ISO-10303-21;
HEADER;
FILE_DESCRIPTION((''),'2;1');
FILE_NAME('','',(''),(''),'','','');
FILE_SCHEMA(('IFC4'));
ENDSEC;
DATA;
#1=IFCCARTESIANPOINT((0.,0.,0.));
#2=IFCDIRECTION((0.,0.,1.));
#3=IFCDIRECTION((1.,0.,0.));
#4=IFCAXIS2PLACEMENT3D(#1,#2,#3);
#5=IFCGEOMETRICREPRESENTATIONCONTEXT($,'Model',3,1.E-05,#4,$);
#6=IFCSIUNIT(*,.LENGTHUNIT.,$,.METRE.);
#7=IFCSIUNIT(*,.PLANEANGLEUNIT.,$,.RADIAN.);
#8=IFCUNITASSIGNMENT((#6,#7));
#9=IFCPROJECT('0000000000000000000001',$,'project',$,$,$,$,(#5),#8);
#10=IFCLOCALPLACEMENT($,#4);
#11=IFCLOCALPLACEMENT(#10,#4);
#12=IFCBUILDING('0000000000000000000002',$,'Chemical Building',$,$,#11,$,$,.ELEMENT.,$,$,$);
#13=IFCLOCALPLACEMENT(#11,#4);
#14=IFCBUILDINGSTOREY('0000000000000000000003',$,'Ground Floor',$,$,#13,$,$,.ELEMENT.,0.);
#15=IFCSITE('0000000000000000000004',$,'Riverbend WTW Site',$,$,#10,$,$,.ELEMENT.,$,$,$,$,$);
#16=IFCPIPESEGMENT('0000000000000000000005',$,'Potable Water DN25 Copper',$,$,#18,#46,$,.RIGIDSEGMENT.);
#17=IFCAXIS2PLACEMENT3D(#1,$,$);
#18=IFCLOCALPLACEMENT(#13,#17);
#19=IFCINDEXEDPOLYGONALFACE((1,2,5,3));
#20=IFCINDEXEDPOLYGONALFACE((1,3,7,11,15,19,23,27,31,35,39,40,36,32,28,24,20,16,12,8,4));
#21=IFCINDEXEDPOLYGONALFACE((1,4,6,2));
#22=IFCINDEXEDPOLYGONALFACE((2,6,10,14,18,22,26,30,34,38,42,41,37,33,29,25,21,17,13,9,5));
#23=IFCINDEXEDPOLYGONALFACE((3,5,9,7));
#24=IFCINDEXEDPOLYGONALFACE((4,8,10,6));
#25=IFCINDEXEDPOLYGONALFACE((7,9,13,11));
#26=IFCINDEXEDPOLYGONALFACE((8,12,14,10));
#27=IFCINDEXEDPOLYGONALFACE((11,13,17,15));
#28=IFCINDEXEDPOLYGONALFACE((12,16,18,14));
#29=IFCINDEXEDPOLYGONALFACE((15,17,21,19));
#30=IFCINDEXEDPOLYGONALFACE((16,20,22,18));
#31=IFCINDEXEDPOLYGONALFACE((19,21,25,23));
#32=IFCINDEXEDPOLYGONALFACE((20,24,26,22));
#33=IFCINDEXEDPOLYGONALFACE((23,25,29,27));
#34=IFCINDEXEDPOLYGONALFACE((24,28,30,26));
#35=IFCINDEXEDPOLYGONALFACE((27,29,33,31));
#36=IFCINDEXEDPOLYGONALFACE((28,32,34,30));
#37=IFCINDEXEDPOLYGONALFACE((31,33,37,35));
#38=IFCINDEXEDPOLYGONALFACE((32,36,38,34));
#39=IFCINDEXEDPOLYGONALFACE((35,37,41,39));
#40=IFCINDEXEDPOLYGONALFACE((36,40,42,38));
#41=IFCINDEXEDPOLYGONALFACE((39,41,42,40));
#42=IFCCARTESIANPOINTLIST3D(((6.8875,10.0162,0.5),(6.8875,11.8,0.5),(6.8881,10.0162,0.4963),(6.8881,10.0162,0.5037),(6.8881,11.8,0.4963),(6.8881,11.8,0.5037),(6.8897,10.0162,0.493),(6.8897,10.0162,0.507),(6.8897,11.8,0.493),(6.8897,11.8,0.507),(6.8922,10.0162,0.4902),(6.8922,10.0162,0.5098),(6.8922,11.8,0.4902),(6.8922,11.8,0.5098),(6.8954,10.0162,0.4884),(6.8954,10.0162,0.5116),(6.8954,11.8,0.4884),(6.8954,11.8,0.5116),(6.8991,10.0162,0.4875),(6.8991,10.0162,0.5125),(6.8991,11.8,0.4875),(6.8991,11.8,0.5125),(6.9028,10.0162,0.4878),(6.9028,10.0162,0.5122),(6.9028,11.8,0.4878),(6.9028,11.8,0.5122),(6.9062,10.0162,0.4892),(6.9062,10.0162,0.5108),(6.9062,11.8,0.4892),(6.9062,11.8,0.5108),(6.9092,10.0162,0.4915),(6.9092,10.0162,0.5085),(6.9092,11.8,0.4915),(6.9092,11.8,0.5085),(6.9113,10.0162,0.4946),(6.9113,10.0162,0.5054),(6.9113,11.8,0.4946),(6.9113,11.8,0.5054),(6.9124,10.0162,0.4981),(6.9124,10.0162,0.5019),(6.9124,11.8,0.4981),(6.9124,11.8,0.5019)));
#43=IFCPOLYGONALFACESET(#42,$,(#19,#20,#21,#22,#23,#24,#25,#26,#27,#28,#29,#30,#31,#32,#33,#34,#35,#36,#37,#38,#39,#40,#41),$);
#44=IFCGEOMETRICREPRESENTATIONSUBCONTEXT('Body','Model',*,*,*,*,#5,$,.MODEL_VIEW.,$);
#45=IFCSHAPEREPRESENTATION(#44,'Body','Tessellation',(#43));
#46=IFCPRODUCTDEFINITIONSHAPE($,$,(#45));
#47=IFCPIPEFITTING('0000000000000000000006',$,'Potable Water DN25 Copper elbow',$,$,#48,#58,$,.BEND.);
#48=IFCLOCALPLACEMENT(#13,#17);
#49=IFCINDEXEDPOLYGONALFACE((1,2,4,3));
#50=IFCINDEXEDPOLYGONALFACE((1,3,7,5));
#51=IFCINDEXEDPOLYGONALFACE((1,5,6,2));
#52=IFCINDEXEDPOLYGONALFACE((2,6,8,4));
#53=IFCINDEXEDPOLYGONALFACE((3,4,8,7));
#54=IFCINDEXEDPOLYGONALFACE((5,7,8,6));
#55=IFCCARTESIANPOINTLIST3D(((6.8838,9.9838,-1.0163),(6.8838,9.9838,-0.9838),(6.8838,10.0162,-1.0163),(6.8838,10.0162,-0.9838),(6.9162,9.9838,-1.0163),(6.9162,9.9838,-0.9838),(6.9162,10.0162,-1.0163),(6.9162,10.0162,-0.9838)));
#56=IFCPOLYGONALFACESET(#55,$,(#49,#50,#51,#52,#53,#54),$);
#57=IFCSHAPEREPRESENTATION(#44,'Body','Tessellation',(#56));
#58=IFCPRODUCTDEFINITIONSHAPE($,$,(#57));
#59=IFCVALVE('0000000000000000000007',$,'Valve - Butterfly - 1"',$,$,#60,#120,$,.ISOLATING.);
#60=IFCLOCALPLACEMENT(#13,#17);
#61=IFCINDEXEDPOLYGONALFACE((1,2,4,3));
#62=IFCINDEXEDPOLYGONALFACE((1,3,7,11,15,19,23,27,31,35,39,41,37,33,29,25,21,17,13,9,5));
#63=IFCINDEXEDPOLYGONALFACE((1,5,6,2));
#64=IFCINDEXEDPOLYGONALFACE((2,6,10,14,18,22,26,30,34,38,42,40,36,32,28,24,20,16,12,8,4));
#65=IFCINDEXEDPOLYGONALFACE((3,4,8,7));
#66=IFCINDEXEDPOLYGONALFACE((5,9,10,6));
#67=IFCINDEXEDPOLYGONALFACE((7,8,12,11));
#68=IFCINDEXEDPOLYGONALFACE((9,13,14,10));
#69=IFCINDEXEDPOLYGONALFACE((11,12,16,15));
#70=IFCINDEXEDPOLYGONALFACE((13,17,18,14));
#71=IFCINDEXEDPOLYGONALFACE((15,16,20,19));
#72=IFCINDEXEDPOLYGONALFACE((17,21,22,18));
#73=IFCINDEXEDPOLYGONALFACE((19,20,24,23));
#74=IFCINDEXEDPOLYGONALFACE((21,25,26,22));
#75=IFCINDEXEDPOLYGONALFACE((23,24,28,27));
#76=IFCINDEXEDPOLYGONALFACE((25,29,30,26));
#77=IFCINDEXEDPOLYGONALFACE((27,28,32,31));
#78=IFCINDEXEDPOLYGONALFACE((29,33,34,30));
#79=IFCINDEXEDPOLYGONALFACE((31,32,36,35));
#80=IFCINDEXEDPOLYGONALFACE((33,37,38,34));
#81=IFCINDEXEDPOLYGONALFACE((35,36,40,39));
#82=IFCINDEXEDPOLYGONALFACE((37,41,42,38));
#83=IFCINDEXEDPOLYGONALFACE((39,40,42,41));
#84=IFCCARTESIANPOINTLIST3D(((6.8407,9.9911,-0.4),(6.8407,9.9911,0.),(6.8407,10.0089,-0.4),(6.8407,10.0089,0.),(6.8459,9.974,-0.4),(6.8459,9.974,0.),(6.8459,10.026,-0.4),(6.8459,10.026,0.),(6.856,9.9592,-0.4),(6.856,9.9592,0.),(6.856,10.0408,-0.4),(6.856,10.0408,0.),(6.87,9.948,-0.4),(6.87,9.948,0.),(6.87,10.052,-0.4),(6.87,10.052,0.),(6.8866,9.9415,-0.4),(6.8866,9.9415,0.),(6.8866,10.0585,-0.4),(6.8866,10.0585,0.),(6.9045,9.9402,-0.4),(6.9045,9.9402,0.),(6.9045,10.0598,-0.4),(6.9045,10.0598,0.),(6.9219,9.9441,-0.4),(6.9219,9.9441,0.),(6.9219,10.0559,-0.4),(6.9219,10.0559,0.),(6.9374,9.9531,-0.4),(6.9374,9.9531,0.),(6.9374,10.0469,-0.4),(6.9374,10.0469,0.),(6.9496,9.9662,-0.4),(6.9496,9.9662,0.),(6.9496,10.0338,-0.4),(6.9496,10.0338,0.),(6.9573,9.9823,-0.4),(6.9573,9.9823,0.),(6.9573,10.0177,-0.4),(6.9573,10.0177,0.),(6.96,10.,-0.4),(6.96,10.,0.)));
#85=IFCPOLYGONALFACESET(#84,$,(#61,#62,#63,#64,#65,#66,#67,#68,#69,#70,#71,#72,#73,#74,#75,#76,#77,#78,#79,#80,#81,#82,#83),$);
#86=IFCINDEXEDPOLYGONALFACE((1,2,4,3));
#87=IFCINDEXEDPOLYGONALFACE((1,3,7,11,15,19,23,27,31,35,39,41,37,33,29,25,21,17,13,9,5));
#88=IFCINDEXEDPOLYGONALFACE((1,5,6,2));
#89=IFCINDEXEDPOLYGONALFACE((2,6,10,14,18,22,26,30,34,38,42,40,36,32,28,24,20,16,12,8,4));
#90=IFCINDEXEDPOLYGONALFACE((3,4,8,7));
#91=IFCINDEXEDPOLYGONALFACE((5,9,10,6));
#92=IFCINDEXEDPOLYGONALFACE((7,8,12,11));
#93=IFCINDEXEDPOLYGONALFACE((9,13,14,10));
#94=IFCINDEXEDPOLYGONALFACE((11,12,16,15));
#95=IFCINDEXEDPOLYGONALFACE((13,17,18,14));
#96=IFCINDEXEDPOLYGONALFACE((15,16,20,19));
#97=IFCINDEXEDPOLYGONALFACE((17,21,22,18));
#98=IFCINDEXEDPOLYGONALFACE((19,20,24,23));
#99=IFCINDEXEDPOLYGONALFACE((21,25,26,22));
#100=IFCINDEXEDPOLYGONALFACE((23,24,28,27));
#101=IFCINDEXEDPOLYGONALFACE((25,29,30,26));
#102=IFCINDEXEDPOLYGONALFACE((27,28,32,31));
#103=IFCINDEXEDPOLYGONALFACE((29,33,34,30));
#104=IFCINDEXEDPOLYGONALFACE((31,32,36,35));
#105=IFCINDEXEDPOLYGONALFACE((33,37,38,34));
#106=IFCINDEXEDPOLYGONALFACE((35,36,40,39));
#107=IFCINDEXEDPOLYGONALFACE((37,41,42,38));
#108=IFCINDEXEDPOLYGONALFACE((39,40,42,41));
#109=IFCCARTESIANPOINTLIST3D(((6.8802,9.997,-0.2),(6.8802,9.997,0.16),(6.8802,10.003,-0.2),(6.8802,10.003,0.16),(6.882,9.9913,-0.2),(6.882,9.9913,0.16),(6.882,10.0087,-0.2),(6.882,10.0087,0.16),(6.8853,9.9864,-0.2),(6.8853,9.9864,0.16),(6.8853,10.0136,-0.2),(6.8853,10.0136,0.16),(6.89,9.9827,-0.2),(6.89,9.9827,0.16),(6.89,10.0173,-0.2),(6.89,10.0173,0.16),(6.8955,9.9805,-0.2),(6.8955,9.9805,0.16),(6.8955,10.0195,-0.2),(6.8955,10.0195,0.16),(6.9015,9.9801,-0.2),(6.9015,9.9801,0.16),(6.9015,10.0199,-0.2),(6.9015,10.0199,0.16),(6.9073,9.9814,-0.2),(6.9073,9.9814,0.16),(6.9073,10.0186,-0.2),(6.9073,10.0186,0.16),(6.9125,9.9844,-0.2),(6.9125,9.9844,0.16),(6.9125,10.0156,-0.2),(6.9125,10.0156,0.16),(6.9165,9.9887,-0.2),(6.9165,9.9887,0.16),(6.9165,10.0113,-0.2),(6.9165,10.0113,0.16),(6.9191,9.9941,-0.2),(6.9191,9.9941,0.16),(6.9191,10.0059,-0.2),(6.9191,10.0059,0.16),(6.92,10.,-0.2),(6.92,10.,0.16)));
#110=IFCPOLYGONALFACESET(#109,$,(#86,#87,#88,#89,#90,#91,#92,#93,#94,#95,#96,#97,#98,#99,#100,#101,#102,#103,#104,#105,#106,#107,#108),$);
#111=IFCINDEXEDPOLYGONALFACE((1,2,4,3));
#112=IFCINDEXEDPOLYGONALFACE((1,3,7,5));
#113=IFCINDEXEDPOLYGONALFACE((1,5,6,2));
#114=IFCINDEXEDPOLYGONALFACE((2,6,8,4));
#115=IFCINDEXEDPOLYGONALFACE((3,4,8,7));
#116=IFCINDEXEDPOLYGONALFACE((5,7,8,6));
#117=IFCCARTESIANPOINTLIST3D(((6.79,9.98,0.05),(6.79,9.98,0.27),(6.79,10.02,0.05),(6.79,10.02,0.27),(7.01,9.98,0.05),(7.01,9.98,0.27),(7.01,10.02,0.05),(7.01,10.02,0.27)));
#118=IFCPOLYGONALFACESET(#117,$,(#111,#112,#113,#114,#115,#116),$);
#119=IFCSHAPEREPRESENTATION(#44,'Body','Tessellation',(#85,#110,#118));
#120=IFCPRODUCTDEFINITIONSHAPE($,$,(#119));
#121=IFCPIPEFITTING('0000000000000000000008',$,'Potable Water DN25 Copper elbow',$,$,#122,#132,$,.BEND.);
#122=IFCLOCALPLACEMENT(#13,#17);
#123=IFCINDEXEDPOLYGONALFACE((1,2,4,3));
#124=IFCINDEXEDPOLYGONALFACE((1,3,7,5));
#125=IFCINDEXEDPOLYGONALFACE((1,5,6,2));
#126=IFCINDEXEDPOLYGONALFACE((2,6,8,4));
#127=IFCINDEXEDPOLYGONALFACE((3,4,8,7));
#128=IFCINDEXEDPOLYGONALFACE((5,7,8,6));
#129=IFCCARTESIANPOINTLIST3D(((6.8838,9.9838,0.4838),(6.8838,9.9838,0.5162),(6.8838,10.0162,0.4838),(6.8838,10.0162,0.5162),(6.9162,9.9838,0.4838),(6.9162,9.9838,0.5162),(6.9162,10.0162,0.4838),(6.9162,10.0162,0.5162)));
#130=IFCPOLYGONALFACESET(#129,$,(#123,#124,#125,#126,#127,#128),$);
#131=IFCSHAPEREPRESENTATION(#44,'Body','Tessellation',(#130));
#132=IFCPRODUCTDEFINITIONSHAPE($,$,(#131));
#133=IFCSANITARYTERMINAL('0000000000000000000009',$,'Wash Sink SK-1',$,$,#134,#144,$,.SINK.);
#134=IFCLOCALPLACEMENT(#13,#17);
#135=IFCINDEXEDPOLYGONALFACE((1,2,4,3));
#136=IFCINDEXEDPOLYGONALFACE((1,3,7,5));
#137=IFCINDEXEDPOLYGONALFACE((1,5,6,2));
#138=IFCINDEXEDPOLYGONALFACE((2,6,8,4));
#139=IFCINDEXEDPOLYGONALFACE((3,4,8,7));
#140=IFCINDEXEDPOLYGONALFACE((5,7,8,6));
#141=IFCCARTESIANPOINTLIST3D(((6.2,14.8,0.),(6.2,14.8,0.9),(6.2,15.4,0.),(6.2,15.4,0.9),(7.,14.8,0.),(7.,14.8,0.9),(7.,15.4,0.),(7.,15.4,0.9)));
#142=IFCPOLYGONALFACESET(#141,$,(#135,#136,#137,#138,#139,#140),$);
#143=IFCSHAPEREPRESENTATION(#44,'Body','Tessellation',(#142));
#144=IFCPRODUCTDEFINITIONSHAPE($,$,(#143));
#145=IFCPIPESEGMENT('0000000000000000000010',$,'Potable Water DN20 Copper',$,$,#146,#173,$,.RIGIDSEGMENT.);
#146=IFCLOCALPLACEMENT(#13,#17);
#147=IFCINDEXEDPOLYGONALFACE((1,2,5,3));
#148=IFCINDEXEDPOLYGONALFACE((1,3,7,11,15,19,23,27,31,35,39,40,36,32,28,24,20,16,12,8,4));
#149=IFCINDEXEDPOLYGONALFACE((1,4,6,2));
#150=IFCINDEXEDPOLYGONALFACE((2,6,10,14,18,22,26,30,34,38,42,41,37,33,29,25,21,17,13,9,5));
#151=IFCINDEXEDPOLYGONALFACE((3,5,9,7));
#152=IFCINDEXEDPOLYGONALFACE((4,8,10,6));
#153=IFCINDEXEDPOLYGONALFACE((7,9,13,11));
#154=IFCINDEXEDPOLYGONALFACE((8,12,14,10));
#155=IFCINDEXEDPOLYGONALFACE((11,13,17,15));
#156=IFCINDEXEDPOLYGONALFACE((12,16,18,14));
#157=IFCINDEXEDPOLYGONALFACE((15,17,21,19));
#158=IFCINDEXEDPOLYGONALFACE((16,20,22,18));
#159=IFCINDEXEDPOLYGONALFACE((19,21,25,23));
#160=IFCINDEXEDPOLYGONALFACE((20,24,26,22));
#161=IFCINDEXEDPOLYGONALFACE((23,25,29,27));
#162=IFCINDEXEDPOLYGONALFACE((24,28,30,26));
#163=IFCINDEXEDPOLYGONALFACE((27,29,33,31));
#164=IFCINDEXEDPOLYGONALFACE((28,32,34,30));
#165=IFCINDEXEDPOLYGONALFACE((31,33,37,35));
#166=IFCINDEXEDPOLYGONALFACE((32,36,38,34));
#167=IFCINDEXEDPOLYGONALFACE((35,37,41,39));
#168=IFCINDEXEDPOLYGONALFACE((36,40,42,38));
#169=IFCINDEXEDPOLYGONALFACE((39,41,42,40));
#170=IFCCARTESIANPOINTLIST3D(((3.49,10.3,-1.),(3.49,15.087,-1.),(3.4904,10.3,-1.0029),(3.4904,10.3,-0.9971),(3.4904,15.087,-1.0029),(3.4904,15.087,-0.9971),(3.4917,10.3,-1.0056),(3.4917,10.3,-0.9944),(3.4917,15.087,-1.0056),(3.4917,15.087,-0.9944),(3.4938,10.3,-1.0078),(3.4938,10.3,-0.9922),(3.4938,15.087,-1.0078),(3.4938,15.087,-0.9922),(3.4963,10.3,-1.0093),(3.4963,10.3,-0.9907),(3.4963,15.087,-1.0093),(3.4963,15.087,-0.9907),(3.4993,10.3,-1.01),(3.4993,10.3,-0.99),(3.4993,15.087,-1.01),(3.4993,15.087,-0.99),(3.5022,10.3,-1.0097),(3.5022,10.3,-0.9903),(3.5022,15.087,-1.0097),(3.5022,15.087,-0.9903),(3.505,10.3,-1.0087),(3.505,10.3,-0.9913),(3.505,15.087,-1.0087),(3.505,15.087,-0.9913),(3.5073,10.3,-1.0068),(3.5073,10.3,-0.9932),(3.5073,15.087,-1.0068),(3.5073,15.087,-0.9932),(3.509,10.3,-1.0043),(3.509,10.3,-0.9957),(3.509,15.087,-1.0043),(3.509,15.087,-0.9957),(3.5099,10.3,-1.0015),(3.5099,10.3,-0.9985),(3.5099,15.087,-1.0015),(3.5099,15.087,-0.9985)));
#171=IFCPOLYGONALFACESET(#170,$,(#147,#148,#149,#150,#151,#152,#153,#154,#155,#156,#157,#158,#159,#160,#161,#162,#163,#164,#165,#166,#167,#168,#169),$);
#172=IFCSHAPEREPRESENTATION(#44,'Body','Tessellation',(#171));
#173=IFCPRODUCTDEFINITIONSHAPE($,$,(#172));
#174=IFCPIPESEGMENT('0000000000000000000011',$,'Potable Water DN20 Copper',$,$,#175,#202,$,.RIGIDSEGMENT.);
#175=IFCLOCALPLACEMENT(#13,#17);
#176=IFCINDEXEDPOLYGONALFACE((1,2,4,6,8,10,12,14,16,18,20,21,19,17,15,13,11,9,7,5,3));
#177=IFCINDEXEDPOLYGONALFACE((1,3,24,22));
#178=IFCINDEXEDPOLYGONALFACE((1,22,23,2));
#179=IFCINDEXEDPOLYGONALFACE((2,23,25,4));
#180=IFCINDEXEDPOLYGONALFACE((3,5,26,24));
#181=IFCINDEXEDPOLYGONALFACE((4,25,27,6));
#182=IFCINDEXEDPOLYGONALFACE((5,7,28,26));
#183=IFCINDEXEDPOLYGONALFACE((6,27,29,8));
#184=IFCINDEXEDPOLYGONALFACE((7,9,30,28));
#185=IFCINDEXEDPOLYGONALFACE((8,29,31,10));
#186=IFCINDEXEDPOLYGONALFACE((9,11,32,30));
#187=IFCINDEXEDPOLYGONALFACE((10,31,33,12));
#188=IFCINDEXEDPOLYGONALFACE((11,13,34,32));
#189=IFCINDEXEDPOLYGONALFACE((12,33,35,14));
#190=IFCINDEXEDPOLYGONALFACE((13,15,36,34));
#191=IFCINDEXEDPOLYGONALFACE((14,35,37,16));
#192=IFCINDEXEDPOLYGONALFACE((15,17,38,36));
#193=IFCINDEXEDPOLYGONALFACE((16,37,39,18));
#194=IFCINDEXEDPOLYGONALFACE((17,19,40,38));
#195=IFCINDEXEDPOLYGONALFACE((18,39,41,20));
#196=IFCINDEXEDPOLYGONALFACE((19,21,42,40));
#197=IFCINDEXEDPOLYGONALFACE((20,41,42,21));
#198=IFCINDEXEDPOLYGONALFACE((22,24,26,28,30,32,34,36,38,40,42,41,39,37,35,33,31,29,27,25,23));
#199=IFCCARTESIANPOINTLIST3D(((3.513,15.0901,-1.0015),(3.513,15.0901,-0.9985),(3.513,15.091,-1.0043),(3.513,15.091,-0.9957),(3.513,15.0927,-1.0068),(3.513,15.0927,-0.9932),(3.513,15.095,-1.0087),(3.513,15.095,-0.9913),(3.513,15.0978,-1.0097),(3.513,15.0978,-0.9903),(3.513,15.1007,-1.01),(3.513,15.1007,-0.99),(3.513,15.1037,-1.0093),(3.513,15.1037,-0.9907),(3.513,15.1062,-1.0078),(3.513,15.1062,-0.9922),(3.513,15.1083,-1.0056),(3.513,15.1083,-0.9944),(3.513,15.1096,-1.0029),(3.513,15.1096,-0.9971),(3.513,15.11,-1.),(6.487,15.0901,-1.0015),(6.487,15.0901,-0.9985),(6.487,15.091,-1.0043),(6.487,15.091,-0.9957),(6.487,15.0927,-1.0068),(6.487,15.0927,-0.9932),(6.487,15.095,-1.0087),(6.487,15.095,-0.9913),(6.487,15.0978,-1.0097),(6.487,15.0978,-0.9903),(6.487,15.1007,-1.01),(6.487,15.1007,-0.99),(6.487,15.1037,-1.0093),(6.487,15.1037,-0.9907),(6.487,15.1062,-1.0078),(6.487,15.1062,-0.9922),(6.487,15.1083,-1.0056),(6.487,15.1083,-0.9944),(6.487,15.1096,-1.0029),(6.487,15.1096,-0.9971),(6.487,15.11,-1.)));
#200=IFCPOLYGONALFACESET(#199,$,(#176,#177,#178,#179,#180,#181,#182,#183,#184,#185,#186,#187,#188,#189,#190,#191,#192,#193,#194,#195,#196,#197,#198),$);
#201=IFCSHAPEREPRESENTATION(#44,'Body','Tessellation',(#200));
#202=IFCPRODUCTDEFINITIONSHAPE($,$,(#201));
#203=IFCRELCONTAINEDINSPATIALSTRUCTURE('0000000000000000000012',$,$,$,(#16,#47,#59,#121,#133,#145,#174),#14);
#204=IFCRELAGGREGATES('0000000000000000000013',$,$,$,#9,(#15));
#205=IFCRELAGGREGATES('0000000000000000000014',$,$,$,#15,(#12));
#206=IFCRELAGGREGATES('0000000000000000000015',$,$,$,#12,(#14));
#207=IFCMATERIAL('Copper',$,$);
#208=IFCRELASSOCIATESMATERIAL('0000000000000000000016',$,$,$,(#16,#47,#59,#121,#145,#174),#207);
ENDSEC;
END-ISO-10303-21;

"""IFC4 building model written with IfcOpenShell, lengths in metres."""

from ifc_helpers import new_model, si_unit, frame, origin_with_axes, origin_2d, place, context, subcontext, project, spatial, rectangle, circle, extrude, material, element, save


model = new_model("IFC4")

# Units and contexts
model_context = context("Model", 3, precision=1e-05, world=origin_with_axes())
body_context = subcontext(model_context, "Body", "Model", "MODEL_VIEW")
ifc_project = project(units=[si_unit("LENGTHUNIT", "METRE"), si_unit("PLANEANGLEUNIT", "RADIAN")], contexts=[model_context])

# Site, building, storey
site_placement = place(None, origin_with_axes())
site = spatial("IfcSite", under=ifc_project, at=site_placement, Name="Riverbend WTW Site", CompositionType="ELEMENT")
building_placement = place(site_placement, origin_with_axes())
building = spatial("IfcBuilding", under=site, at=building_placement, Name="Chemical Building", CompositionType="ELEMENT")
storey_placement = place(building_placement, origin_with_axes())
storey = spatial("IfcBuildingStorey", under=building, at=storey_placement, Name="Ground Floor", CompositionType="ELEMENT", Elevation=0.0)

# Pipe segment
ifc_material_1 = material(Name="Copper")
pipe_segment_1_placement = place(None, frame((6.9, 10.0162, 0.5), z_axis=(0.0, 0.0, 1.0), x_axis=(1.0, 0.0, 0.0)))
element("IfcPipeSegment", 1, at=pipe_segment_1_placement, inside=storey, material=ifc_material_1, Name="Potable Water DN25 Copper", PredefinedType="RIGIDSEGMENT", context=body_context, shape_type="SweptSolid", body=[
    extrude(circle(Radius=0.0125, at=origin_2d()), frame((0.0, 0.0, 0.0), z_axis=(0.0, 1.0, 0.0), x_axis=(-1.0, 0.0, 0.0)), (0.0, 0.0, 1.0), 1.7838),
])

# Pipe fitting
pipe_fitting_1_placement = place(None, frame((6.9, 10.0, -1.0), z_axis=(0.0, 0.0, 1.0), x_axis=(1.0, 0.0, 0.0)))
element("IfcPipeFitting", 2, at=pipe_fitting_1_placement, inside=storey, material=ifc_material_1, Name="Potable Water DN25 Copper elbow", PredefinedType="BEND", context=body_context, shape_type="SweptSolid", body=[
    extrude(rectangle(XDim=0.0325, YDim=0.0325, at=origin_2d()), frame((0.0, 0.0, -0.0163), z_axis=(0.0, 0.0, 1.0), x_axis=(1.0, 0.0, 0.0)), (0.0, 0.0, 1.0), 0.0325),
])

# Valve
valve_placement = place(None, frame((6.9, 10.0, -0.4), z_axis=(0.0, 0.0, 1.0), x_axis=(1.0, 0.0, 0.0)))
element("IfcValve", 3, at=valve_placement, inside=storey, material=ifc_material_1, Name="Valve - Butterfly - 1\"", PredefinedType="ISOLATING", context=body_context, shape_type="SweptSolid", body=[
    extrude(circle(Radius=0.06, at=origin_2d()), origin_with_axes(), (0.0, 0.0, 1.0), 0.4),
    extrude(circle(Radius=0.02, at=origin_2d()), frame((0.0, 0.0, 0.2), z_axis=(0.0, 0.0, 1.0), x_axis=(1.0, 0.0, 0.0)), (0.0, 0.0, 1.0), 0.36),
    extrude(rectangle(XDim=0.22, YDim=0.04, at=origin_2d()), frame((0.0, 0.0, 0.45), z_axis=(0.0, 0.0, 1.0), x_axis=(1.0, 0.0, 0.0)), (0.0, 0.0, 1.0), 0.22),
])

# Pipe fitting
pipe_fitting_2_placement = place(None, frame((6.9, 10.0, 0.5), z_axis=(0.0, 0.0, 1.0), x_axis=(1.0, 0.0, 0.0)))
element("IfcPipeFitting", 4, at=pipe_fitting_2_placement, inside=storey, material=ifc_material_1, Name="Potable Water DN25 Copper elbow", PredefinedType="BEND", context=body_context, shape_type="SweptSolid", body=[
    extrude(rectangle(XDim=0.0325, YDim=0.0325, at=origin_2d()), frame((0.0, 0.0, -0.0162), z_axis=(0.0, 0.0, 1.0), x_axis=(1.0, 0.0, 0.0)), (0.0, 0.0, 1.0), 0.0325),
])

# Sanitary terminal
sanitary_terminal_1_placement = place(None, frame((6.6, 15.1, 0.45), z_axis=(0.0, 0.0, 1.0), x_axis=(1.0, 0.0, 0.0)))
element("IfcSanitaryTerminal", 5, at=sanitary_terminal_1_placement, inside=storey, Name="Wash Sink SK-1", PredefinedType="SINK", context=body_context, shape_type="SweptSolid", body=[
    extrude(rectangle(XDim=0.8, YDim=0.6, at=origin_2d()), frame((0.0, 0.0, -0.45), z_axis=(0.0, 0.0, 1.0), x_axis=(1.0, 0.0, 0.0)), (0.0, 0.0, 1.0), 0.9),
])

# Pipe segments
pipe_segment_2_placement = place(None, frame((3.5, 10.3, -1.0), z_axis=(0.0, 0.0, 1.0), x_axis=(1.0, 0.0, 0.0)))
element("IfcPipeSegment", 6, at=pipe_segment_2_placement, inside=storey, material=ifc_material_1, Name="Potable Water DN20 Copper", PredefinedType="RIGIDSEGMENT", context=body_context, shape_type="SweptSolid", body=[
    extrude(circle(Radius=0.01, at=origin_2d()), frame((0.0, 0.0, 0.0), z_axis=(0.0, 1.0, 0.0), x_axis=(-1.0, 0.0, 0.0)), (0.0, 0.0, 1.0), 4.787),
])
pipe_segment_3_placement = place(None, frame((3.513, 15.1, -1.0), z_axis=(0.0, 0.0, 1.0), x_axis=(1.0, 0.0, 0.0)))
element("IfcPipeSegment", 7, at=pipe_segment_3_placement, inside=storey, material=ifc_material_1, Name="Potable Water DN20 Copper", PredefinedType="RIGIDSEGMENT", context=body_context, shape_type="SweptSolid", body=[
    extrude(circle(Radius=0.01, at=origin_2d()), frame((0.0, 0.0, 0.0), z_axis=(1.0, 0.0, 0.0), x_axis=(0.0, 1.0, 0.0)), (0.0, 0.0, 1.0), 2.974),
])

save(model, "model.ifc")
